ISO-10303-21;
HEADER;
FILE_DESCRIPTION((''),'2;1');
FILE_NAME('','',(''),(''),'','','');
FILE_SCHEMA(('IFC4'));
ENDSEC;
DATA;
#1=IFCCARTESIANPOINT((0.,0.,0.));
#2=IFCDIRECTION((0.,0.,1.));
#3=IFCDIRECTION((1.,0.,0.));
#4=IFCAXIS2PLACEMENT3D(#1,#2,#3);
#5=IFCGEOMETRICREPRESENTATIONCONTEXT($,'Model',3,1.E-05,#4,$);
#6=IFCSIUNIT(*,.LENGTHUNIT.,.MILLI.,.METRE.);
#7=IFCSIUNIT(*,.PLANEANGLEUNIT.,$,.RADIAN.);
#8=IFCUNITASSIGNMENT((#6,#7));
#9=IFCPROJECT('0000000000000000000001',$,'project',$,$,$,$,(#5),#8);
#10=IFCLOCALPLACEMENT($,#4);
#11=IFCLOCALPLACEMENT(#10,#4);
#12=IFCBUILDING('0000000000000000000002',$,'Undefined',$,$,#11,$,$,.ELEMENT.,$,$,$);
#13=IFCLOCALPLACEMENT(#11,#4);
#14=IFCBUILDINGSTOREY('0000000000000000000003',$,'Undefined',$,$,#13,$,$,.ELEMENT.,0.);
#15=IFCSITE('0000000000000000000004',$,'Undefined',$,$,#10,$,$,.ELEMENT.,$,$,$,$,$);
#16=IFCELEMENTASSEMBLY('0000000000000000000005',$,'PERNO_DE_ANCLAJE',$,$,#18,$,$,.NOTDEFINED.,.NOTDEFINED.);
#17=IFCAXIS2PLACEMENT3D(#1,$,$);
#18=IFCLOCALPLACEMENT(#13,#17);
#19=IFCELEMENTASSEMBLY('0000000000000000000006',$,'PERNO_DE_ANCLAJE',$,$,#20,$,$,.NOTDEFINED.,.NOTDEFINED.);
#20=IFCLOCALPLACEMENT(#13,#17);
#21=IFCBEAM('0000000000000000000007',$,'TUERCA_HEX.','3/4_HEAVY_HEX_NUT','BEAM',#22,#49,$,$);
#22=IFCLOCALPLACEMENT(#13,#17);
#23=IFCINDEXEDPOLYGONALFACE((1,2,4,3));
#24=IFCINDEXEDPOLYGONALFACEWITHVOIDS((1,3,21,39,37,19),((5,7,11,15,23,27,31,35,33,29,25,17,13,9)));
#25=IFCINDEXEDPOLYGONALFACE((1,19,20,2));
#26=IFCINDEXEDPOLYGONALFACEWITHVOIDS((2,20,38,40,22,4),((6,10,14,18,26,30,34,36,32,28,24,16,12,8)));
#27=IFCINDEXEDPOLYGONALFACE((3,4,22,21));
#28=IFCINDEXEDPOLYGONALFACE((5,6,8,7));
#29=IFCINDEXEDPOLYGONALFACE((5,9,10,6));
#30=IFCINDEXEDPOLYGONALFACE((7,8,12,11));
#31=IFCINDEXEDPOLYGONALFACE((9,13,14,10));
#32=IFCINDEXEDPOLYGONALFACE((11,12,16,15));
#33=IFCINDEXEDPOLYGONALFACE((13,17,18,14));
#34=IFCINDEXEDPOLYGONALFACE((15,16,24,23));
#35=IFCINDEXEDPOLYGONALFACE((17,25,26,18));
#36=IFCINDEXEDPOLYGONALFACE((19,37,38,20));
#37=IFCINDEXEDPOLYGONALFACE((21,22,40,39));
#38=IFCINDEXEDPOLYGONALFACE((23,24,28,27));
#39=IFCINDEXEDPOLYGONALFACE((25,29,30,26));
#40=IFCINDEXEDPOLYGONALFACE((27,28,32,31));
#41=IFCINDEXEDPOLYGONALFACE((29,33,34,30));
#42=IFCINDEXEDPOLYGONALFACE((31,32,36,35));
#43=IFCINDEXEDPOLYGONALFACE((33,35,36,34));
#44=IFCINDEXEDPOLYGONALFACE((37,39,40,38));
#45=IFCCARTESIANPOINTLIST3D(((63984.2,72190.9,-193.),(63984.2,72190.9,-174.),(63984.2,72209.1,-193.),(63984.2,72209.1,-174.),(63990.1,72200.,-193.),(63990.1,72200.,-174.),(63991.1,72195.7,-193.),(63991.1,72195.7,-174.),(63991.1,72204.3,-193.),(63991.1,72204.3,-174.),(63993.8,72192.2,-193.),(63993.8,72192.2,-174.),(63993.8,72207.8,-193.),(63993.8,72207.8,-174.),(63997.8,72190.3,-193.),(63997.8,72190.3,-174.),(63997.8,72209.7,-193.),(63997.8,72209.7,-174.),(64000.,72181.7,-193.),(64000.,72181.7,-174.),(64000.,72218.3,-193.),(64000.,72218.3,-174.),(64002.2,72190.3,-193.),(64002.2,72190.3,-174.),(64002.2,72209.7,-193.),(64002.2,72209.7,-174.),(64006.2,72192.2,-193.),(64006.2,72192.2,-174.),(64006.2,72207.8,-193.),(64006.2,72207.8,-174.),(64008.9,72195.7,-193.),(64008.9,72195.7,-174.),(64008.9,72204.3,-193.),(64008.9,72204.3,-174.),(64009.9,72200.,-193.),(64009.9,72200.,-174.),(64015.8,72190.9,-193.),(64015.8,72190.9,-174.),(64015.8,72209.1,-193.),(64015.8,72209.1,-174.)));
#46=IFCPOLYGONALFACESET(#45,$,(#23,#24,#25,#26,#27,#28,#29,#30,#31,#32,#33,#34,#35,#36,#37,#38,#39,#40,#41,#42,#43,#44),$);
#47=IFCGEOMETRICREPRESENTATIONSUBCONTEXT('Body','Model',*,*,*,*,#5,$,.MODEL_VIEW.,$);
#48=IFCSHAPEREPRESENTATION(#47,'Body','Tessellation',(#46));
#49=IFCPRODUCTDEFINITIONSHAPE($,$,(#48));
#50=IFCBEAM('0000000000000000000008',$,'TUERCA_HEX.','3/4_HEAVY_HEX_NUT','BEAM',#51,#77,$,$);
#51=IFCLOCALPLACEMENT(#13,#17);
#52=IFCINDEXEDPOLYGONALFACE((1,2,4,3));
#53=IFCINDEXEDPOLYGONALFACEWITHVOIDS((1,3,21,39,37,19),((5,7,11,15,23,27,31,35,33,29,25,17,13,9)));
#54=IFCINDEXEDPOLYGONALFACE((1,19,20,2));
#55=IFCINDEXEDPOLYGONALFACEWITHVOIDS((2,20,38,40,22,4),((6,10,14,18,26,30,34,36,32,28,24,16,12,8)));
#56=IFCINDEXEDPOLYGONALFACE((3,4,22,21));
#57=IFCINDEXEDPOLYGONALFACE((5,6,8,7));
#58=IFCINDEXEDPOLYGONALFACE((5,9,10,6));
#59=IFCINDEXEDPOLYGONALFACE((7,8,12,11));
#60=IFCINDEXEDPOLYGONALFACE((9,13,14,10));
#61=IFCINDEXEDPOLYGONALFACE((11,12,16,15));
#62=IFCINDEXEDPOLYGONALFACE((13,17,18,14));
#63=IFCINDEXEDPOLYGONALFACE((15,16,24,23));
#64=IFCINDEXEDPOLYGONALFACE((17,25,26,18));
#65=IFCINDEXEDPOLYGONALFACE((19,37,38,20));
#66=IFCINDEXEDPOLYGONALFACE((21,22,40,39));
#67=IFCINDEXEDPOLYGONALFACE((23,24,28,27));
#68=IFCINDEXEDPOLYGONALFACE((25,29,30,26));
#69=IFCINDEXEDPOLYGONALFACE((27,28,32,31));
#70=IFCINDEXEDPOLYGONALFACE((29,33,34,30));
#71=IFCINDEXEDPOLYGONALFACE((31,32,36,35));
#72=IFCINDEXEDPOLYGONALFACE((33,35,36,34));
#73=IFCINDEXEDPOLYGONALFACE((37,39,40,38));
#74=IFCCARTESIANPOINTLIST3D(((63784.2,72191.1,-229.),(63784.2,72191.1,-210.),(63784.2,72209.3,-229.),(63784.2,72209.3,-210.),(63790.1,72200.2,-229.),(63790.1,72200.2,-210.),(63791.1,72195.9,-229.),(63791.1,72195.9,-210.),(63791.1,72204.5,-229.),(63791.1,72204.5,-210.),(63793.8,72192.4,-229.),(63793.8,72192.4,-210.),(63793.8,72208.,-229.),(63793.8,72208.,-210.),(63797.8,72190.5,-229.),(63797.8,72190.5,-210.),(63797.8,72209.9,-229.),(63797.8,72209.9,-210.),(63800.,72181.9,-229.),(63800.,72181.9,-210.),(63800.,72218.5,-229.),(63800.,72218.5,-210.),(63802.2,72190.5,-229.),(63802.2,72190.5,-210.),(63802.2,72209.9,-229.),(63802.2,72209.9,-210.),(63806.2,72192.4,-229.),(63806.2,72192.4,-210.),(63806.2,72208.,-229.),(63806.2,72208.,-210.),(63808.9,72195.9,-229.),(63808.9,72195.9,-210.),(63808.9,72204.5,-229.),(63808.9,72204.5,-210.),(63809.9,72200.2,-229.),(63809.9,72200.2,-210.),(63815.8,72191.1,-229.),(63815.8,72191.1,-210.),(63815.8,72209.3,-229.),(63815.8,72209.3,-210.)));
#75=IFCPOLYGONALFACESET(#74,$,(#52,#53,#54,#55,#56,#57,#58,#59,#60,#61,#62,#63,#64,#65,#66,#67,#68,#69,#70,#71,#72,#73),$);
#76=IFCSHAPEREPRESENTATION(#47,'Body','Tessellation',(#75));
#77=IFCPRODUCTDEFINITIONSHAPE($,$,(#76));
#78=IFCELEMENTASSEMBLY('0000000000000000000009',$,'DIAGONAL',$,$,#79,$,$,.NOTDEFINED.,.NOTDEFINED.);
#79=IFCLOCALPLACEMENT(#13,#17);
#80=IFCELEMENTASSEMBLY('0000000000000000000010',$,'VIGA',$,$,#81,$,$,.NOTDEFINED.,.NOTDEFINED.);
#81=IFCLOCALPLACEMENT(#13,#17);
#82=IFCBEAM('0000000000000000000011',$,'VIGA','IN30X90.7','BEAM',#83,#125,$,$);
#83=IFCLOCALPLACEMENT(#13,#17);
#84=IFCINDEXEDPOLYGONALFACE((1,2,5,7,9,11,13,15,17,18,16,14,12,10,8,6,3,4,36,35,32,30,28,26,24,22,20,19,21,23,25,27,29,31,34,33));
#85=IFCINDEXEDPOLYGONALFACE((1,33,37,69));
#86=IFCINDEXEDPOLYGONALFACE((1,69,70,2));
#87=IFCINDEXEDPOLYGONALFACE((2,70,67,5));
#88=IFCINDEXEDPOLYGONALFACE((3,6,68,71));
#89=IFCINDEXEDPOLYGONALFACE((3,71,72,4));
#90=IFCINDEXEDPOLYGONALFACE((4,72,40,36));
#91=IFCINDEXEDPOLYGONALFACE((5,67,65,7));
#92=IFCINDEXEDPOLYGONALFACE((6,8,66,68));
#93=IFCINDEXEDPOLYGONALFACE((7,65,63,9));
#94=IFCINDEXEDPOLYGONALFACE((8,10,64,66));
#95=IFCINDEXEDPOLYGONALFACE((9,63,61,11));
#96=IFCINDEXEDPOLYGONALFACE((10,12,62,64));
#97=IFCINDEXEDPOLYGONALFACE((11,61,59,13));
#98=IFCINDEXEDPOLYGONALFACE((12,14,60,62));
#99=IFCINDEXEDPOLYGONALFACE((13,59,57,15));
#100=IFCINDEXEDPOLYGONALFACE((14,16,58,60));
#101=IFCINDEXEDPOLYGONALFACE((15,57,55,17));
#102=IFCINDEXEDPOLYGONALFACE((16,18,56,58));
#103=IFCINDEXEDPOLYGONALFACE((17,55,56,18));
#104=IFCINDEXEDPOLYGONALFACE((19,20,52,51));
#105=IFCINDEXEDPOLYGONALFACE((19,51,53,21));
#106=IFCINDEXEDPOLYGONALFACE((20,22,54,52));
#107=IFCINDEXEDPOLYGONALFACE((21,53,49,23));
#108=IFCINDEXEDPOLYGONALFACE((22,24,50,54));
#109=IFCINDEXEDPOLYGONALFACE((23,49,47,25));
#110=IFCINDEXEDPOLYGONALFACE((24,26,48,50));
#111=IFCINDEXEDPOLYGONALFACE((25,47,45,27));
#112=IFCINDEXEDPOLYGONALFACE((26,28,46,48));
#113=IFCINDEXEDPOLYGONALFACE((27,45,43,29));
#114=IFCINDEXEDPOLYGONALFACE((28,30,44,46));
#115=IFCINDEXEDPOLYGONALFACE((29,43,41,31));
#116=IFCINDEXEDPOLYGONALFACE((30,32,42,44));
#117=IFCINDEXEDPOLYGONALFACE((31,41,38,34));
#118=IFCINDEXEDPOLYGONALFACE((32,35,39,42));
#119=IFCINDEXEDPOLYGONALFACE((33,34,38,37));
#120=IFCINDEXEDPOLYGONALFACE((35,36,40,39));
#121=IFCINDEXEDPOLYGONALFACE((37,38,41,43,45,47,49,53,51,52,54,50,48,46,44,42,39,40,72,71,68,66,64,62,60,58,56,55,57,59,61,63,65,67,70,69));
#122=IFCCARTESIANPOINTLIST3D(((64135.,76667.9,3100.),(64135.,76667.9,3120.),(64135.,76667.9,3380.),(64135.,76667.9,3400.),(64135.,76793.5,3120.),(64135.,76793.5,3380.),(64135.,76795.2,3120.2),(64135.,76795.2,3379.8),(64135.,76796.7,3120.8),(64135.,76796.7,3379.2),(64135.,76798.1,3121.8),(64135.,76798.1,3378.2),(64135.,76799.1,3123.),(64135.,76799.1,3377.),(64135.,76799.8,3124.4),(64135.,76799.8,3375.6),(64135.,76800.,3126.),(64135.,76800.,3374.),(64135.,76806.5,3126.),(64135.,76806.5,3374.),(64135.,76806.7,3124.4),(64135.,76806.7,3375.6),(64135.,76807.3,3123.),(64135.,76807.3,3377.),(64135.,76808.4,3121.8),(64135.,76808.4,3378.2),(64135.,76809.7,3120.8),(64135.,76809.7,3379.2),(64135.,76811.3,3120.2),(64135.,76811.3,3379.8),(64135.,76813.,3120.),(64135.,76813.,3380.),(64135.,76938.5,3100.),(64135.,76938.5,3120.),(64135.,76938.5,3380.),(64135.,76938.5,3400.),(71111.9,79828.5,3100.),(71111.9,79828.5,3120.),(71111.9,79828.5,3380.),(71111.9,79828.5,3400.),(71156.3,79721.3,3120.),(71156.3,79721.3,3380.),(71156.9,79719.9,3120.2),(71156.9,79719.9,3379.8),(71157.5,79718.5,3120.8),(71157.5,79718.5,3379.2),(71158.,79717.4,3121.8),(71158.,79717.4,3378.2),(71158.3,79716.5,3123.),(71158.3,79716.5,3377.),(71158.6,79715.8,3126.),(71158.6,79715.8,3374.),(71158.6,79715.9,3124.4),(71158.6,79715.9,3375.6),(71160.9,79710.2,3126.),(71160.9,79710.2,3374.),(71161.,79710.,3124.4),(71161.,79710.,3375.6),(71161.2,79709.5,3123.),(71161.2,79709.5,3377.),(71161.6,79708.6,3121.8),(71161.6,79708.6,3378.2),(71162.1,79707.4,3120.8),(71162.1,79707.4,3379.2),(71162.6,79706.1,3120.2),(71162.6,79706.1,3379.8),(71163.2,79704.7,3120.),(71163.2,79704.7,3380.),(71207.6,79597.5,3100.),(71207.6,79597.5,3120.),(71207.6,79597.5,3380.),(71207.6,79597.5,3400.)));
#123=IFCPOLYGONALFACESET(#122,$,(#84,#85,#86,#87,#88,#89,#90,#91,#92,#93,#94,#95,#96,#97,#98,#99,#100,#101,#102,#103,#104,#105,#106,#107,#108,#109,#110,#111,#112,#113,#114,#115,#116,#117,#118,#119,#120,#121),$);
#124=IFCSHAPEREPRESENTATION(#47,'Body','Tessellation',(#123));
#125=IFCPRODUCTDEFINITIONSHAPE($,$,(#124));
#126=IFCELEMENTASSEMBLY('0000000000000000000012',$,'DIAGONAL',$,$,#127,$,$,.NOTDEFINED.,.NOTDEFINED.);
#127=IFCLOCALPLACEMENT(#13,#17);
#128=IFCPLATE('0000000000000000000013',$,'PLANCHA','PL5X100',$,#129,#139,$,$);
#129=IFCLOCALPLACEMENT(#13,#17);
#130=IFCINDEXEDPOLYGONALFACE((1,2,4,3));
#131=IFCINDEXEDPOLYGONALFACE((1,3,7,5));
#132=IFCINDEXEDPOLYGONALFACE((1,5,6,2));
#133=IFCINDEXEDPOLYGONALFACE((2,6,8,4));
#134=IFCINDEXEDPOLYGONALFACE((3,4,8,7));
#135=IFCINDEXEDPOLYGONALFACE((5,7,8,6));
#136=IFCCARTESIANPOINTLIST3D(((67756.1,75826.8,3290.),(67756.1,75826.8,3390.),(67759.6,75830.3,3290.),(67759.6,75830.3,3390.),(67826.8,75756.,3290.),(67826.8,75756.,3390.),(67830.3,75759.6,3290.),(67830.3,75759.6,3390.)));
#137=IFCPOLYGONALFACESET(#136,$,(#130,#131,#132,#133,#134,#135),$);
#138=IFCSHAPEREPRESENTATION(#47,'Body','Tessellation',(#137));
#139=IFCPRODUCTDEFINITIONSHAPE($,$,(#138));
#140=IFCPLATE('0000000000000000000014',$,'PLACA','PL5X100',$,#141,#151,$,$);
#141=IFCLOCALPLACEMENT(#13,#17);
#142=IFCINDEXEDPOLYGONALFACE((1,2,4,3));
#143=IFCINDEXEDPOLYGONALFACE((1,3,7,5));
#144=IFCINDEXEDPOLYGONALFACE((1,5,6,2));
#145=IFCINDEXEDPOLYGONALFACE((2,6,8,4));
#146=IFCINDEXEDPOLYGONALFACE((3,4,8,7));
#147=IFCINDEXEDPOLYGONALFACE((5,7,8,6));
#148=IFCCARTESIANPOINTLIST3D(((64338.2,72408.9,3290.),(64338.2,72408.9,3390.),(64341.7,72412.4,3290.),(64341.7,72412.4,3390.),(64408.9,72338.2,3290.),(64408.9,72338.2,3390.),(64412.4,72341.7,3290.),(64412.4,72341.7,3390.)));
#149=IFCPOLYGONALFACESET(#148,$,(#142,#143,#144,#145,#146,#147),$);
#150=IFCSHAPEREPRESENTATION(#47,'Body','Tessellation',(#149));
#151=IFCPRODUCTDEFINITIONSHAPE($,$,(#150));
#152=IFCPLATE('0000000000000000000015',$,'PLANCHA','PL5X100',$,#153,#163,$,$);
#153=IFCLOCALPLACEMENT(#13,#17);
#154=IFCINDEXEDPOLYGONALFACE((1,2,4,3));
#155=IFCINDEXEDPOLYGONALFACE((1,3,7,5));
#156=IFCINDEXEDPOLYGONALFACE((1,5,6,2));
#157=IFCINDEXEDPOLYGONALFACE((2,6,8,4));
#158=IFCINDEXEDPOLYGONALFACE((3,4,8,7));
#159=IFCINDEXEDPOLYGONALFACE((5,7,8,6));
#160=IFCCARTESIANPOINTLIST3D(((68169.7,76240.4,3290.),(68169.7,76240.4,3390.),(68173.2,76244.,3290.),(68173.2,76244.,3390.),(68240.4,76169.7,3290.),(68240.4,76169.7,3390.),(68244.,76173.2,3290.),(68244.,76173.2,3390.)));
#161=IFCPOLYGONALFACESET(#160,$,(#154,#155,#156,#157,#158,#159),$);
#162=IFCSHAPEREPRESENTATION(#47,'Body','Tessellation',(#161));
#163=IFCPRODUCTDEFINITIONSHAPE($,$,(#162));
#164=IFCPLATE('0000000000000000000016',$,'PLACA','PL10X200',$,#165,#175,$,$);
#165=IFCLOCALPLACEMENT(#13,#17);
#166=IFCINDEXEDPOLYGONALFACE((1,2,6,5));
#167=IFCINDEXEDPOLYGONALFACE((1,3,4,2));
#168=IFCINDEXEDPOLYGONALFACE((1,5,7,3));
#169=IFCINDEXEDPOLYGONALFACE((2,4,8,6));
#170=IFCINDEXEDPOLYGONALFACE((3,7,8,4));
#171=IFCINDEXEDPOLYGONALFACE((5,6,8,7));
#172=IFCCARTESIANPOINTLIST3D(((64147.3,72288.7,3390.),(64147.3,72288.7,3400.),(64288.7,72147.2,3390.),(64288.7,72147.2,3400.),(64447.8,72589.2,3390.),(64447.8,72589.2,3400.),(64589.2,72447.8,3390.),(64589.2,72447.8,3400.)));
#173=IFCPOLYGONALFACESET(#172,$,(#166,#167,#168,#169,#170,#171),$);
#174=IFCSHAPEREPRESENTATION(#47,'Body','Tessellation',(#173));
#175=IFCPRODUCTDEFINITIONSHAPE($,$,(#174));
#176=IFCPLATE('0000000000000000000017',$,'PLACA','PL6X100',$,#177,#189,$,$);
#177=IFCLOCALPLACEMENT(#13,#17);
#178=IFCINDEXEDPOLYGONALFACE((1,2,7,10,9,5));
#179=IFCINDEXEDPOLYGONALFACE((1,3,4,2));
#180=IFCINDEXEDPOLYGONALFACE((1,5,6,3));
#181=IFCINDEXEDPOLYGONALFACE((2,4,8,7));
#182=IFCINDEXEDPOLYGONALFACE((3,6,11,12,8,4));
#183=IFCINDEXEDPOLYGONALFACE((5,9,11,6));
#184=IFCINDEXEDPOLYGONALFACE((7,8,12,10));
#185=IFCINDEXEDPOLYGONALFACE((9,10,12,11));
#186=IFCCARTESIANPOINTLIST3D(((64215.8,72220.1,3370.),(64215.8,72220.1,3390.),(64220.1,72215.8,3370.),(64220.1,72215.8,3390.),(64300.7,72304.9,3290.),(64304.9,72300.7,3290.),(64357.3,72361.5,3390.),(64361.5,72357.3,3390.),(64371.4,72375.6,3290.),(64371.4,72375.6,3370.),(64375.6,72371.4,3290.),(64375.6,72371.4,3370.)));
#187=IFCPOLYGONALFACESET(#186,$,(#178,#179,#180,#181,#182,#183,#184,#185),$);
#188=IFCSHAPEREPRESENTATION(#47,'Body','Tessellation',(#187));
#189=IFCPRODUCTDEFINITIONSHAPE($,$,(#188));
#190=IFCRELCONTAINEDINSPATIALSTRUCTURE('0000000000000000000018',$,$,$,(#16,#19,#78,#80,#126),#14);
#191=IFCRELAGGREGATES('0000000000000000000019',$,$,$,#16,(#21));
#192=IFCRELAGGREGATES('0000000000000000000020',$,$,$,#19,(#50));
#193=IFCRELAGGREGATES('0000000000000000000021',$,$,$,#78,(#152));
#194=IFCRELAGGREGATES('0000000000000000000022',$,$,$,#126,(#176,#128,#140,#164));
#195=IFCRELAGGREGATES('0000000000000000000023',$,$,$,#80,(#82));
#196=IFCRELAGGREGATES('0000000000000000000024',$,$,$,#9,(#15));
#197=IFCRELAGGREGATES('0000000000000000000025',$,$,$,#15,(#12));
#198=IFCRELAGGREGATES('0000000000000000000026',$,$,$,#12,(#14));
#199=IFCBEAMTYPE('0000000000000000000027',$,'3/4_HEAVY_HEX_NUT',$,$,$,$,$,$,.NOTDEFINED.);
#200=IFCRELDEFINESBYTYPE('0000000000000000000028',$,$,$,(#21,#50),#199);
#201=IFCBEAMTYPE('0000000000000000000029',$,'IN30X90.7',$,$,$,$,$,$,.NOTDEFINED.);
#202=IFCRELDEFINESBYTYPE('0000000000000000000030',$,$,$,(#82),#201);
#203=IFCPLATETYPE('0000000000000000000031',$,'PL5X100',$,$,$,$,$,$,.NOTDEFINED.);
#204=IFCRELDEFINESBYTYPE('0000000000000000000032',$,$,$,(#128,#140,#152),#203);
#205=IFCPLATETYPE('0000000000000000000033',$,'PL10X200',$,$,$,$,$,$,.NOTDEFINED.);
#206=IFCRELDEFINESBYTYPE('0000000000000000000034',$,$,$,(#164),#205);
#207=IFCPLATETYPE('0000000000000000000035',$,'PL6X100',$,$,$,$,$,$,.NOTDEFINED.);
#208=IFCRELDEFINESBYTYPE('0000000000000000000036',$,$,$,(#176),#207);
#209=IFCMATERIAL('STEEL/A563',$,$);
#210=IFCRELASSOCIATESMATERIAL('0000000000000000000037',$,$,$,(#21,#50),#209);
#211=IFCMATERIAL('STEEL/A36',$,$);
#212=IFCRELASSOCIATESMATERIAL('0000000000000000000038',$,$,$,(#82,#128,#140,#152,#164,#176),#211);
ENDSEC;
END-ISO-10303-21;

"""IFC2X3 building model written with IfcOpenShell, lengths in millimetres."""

from ifc_helpers import new_model, si_unit, frame, origin_with_axes, origin_2d_with_axis, place, context, subcontext, project, spatial, polyline, i_section, outline, extrude, clip, halfspace, material, type_object, element, aggregate, save


model = new_model("IFC2X3")

# Units and contexts
model_context = context("Model", 3, precision=1e-05, world=origin_with_axes())
body_context = subcontext(model_context, "Body", "Model", "MODEL_VIEW")
ifc_project = project(units=[si_unit("LENGTHUNIT", "METRE", prefix="MILLI"), si_unit("PLANEANGLEUNIT", "RADIAN")], contexts=[model_context])

# Site, building, storey
site_placement = place(None, origin_with_axes())
site = spatial("IfcSite", under=ifc_project, at=site_placement, Name="Undefined", CompositionType="ELEMENT")
building_placement = place(site_placement, origin_with_axes())
building = spatial("IfcBuilding", under=site, at=building_placement, Name="Undefined", CompositionType="ELEMENT")
storey_placement = place(building_placement, origin_with_axes())
storey = spatial("IfcBuildingStorey", under=building, at=storey_placement, Name="Undefined", CompositionType="ELEMENT", Elevation=0.0)

# Shared definitions
ifc_material_1 = material(Name="STEEL/A36")

# Element assemblies
ifc_material_2 = material(Name="STEEL/A563")
assembly_1_placement = place(storey_placement, origin_with_axes())
assembly_1 = element("IfcElementAssembly", 1, at=assembly_1_placement, inside=storey, Name="PERNO_DE_ANCLAJE", AssemblyPlace="NOTDEFINED", PredefinedType="NOTDEFINED")
assembly_2_placement = place(storey_placement, origin_with_axes())
assembly_2 = element("IfcElementAssembly", 2, at=assembly_2_placement, inside=storey, Name="PERNO_DE_ANCLAJE", AssemblyPlace="NOTDEFINED", PredefinedType="NOTDEFINED")
beam_type_1 = type_object("IfcBeamType", Name="3/4_HEAVY_HEX_NUT", PredefinedType="NOTDEFINED")

# Beams
beam_1_placement = place(assembly_1_placement, frame((64000.0, 72200.0, -174.0), z_axis=(1.0, 0.0, 0.0), x_axis=(0.0, 0.0, -1.0)))
beam_1 = element("IfcBeam", 3, at=beam_1_placement, type_object=beam_type_1, material=ifc_material_2, Name="TUERCA_HEX.", Description="3/4_HEAVY_HEX_NUT", ObjectType="BEAM", context=body_context, shape_type="SweptSolid", body=[
    extrude(outline(polyline([(-9.1, -15.8), (-18.3, 0.0), (-9.1, 15.8), (9.1, 15.8), (18.3, 0.0), (9.1, -15.8), (-9.1, -15.8)]), holes=[polyline([(7.8, 6.2), (4.3, 8.9), (0.0, 9.9), (-4.3, 8.9), (-7.8, 6.2), (-9.7, 2.2), (-9.7, -2.2), (-7.8, -6.2), (-4.3, -8.9), (0.0, -9.9), (4.3, -8.9), (7.8, -6.2), (9.7, -2.2), (9.7, 2.2), (7.8, 6.2)])]), frame((19.0, 0.0, 0.0), z_axis=(-1.0, 0.0, 0.0), x_axis=(0.0, -1.0, 0.0)), (0.0, 0.0, 1.0), 19.0),
])
aggregate(assembly_1, [beam_1])
beam_2_placement = place(assembly_2_placement, frame((63800.0, 72200.2, -210.0), z_axis=(1.0, 0.0, 0.0), x_axis=(0.0, 0.0, -1.0)))
beam_2 = element("IfcBeam", 4, at=beam_2_placement, type_object=beam_type_1, material=ifc_material_2, Name="TUERCA_HEX.", Description="3/4_HEAVY_HEX_NUT", ObjectType="BEAM", context=body_context, shape_type="SweptSolid", body=[
    extrude(outline(polyline([(-9.1, -15.8), (-18.3, 0.0), (-9.1, 15.8), (9.1, 15.8), (18.3, 0.0), (9.1, -15.8), (-9.1, -15.8)]), holes=[polyline([(7.8, 6.2), (4.3, 8.9), (0.0, 9.9), (-4.3, 8.9), (-7.8, 6.2), (-9.7, 2.2), (-9.7, -2.2), (-7.8, -6.2), (-4.3, -8.9), (0.0, -9.9), (4.3, -8.9), (7.8, -6.2), (9.7, -2.2), (9.7, 2.2), (7.8, 6.2)])]), frame((19.0, 0.0, 0.0), z_axis=(-1.0, 0.0, 0.0), x_axis=(0.0, -1.0, 0.0)), (0.0, 0.0, 1.0), 19.0),
])
aggregate(assembly_2, [beam_2])

# Element assemblies, beam
assembly_3_placement = place(storey_placement, origin_with_axes())
assembly_3 = element("IfcElementAssembly", 5, at=assembly_3_placement, inside=storey, Name="DIAGONAL", AssemblyPlace="NOTDEFINED", PredefinedType="NOTDEFINED")
assembly_4_placement = place(storey_placement, origin_with_axes())
assembly_4 = element("IfcElementAssembly", 6, at=assembly_4_placement, inside=storey, Name="VIGA", AssemblyPlace="NOTDEFINED", PredefinedType="NOTDEFINED")
beam_type_2 = type_object("IfcBeamType", Name="IN30X90.7", PredefinedType="NOTDEFINED")
beam_3_placement = place(assembly_4_placement, frame((64000.0, 76747.3, 3250.0), z_axis=(0.0, 0.0, 1.0), x_axis=(0.92388, 0.382683, 0.0)))
beam_3 = element("IfcBeam", 7, at=beam_3_placement, type_object=beam_type_2, material=ifc_material_1, Name="VIGA", Description="IN30X90.7", ObjectType="BEAM", context=body_context, shape_type="Clipping", body=[
    clip(extrude(i_section(OverallWidth=250.0, OverallDepth=300.0, WebThickness=6.0, FlangeThickness=20.0, FilletRadius=6.0, at=origin_2d_with_axis()), frame((7749.7, 0.0, 0.0), z_axis=(-1.0, 0.0, 0.0), x_axis=(0.0, -1.0, 0.0)), (0.0, 0.0, 1.0), 7749.7), halfspace(frame((125.2, -50.5, 250.0), z_axis=(-0.92388, 0.382683, 0.0), x_axis=(-0.382684, -0.923879, 0.0)), False)),
])

# Element assembly, plates
assembly_5_placement = place(storey_placement, origin_with_axes())
assembly_5 = element("IfcElementAssembly", 8, at=assembly_5_placement, inside=storey, Name="DIAGONAL", AssemblyPlace="NOTDEFINED", PredefinedType="NOTDEFINED")
plate_type_1 = type_object("IfcPlateType", Name="PL5X100", PredefinedType="NOTDEFINED")
plate_1_placement = place(assembly_5_placement, frame((67793.2, 75793.2, 3390.0), z_axis=(-0.707107, -0.707107, 0.0), x_axis=(0.0, 0.0, -1.0)))
plate_1 = element("IfcPlate", 9, at=plate_1_placement, type_object=plate_type_1, material=ifc_material_1, Name="PLANCHA", Description="PL5X100", context=body_context, shape_type="SweptSolid", body=[
    extrude(outline(polyline([(0.0, -50.0), (0.0, 50.0), (100.0, 50.0), (100.0, -50.0), (0.0, -50.0)])), frame((0.0, 0.0, -2.5), z_axis=(0.0, 0.0, 1.0), x_axis=(1.0, 0.0, 0.0)), (0.0, 0.0, 1.0), 5.0),
])
plate_2_placement = place(assembly_5_placement, frame((64410.6, 72339.9, 3390.0), z_axis=(0.707107, 0.707107, 0.0), x_axis=(0.0, 0.0, -1.0)))
plate_2 = element("IfcPlate", 10, at=plate_2_placement, type_object=plate_type_1, material=ifc_material_1, Name="PLACA", Description="PL5X100", context=body_context, shape_type="SweptSolid", body=[
    extrude(outline(polyline([(0.0, 0.0), (100.0, 0.0), (100.0, 100.0), (0.0, 100.0), (0.0, 0.0)])), frame((0.0, 0.0, -2.5), z_axis=(0.0, 0.0, 1.0), x_axis=(1.0, 0.0, 0.0)), (0.0, 0.0, 1.0), 5.0),
])

# Plates
plate_3_placement = place(assembly_3_placement, frame((68206.8, 76206.8, 3390.0), z_axis=(0.707107, 0.707107, 0.0), x_axis=(0.0, 0.0, -1.0)))
plate_3 = element("IfcPlate", 11, at=plate_3_placement, type_object=plate_type_1, material=ifc_material_1, Name="PLANCHA", Description="PL5X100", context=body_context, shape_type="SweptSolid", body=[
    extrude(outline(polyline([(0.0, -50.0), (0.0, 50.0), (100.0, 50.0), (100.0, -50.0), (0.0, -50.0)])), frame((0.0, 0.0, -2.5), z_axis=(0.0, 0.0, 1.0), x_axis=(1.0, 0.0, 0.0)), (0.0, 0.0, 1.0), 5.0),
])
aggregate(assembly_3, [plate_3])
plate_type_2 = type_object("IfcPlateType", Name="PL10X200", PredefinedType="NOTDEFINED")
plate_4_placement = place(assembly_5_placement, frame((64218.0, 72218.0, 3395.0), z_axis=(0.0, 0.0, -1.0), x_axis=(0.707107, 0.707107, 0.0)))
plate_4 = element("IfcPlate", 12, at=plate_4_placement, type_object=plate_type_2, material=ifc_material_1, Name="PLACA", Description="PL10X200", context=body_context, shape_type="SweptSolid", body=[
    extrude(outline(polyline([(0.0, -100.0), (0.0, 100.0), (425.0, 100.0), (425.0, -100.0), (0.0, -100.0)])), frame((0.0, 0.0, -5.0), z_axis=(0.0, 0.0, 1.0), x_axis=(1.0, 0.0, 0.0)), (0.0, 0.0, 1.0), 10.0),
])

# Plate
plate_type_3 = type_object("IfcPlateType", Name="PL6X100", PredefinedType="NOTDEFINED")
plate_5_placement = place(assembly_5_placement, frame((64218.0, 72218.0, 3290.0), z_axis=(0.707107, -0.707107, 0.0), x_axis=(0.707107, 0.707107, 0.0)))
plate_5 = element("IfcPlate", 13, at=plate_5_placement, type_object=plate_type_3, material=ifc_material_1, Name="PLACA", Description="PL6X100", context=body_context, shape_type="SweptSolid", body=[
    extrude(outline(polyline([(0.0, 80.0), (120.0, 0.0), (220.0, 0.0), (220.0, 80.0), (200.0, 100.0), (0.0, 100.0), (0.0, 80.0)])), frame((0.0, 0.0, -3.0), z_axis=(0.0, 0.0, 1.0), x_axis=(1.0, 0.0, 0.0)), (0.0, 0.0, 1.0), 6.0),
])
aggregate(assembly_5, [plate_5, plate_1, plate_2, plate_4])

aggregate(assembly_4, [beam_3])

save(model, "model.ifc")
